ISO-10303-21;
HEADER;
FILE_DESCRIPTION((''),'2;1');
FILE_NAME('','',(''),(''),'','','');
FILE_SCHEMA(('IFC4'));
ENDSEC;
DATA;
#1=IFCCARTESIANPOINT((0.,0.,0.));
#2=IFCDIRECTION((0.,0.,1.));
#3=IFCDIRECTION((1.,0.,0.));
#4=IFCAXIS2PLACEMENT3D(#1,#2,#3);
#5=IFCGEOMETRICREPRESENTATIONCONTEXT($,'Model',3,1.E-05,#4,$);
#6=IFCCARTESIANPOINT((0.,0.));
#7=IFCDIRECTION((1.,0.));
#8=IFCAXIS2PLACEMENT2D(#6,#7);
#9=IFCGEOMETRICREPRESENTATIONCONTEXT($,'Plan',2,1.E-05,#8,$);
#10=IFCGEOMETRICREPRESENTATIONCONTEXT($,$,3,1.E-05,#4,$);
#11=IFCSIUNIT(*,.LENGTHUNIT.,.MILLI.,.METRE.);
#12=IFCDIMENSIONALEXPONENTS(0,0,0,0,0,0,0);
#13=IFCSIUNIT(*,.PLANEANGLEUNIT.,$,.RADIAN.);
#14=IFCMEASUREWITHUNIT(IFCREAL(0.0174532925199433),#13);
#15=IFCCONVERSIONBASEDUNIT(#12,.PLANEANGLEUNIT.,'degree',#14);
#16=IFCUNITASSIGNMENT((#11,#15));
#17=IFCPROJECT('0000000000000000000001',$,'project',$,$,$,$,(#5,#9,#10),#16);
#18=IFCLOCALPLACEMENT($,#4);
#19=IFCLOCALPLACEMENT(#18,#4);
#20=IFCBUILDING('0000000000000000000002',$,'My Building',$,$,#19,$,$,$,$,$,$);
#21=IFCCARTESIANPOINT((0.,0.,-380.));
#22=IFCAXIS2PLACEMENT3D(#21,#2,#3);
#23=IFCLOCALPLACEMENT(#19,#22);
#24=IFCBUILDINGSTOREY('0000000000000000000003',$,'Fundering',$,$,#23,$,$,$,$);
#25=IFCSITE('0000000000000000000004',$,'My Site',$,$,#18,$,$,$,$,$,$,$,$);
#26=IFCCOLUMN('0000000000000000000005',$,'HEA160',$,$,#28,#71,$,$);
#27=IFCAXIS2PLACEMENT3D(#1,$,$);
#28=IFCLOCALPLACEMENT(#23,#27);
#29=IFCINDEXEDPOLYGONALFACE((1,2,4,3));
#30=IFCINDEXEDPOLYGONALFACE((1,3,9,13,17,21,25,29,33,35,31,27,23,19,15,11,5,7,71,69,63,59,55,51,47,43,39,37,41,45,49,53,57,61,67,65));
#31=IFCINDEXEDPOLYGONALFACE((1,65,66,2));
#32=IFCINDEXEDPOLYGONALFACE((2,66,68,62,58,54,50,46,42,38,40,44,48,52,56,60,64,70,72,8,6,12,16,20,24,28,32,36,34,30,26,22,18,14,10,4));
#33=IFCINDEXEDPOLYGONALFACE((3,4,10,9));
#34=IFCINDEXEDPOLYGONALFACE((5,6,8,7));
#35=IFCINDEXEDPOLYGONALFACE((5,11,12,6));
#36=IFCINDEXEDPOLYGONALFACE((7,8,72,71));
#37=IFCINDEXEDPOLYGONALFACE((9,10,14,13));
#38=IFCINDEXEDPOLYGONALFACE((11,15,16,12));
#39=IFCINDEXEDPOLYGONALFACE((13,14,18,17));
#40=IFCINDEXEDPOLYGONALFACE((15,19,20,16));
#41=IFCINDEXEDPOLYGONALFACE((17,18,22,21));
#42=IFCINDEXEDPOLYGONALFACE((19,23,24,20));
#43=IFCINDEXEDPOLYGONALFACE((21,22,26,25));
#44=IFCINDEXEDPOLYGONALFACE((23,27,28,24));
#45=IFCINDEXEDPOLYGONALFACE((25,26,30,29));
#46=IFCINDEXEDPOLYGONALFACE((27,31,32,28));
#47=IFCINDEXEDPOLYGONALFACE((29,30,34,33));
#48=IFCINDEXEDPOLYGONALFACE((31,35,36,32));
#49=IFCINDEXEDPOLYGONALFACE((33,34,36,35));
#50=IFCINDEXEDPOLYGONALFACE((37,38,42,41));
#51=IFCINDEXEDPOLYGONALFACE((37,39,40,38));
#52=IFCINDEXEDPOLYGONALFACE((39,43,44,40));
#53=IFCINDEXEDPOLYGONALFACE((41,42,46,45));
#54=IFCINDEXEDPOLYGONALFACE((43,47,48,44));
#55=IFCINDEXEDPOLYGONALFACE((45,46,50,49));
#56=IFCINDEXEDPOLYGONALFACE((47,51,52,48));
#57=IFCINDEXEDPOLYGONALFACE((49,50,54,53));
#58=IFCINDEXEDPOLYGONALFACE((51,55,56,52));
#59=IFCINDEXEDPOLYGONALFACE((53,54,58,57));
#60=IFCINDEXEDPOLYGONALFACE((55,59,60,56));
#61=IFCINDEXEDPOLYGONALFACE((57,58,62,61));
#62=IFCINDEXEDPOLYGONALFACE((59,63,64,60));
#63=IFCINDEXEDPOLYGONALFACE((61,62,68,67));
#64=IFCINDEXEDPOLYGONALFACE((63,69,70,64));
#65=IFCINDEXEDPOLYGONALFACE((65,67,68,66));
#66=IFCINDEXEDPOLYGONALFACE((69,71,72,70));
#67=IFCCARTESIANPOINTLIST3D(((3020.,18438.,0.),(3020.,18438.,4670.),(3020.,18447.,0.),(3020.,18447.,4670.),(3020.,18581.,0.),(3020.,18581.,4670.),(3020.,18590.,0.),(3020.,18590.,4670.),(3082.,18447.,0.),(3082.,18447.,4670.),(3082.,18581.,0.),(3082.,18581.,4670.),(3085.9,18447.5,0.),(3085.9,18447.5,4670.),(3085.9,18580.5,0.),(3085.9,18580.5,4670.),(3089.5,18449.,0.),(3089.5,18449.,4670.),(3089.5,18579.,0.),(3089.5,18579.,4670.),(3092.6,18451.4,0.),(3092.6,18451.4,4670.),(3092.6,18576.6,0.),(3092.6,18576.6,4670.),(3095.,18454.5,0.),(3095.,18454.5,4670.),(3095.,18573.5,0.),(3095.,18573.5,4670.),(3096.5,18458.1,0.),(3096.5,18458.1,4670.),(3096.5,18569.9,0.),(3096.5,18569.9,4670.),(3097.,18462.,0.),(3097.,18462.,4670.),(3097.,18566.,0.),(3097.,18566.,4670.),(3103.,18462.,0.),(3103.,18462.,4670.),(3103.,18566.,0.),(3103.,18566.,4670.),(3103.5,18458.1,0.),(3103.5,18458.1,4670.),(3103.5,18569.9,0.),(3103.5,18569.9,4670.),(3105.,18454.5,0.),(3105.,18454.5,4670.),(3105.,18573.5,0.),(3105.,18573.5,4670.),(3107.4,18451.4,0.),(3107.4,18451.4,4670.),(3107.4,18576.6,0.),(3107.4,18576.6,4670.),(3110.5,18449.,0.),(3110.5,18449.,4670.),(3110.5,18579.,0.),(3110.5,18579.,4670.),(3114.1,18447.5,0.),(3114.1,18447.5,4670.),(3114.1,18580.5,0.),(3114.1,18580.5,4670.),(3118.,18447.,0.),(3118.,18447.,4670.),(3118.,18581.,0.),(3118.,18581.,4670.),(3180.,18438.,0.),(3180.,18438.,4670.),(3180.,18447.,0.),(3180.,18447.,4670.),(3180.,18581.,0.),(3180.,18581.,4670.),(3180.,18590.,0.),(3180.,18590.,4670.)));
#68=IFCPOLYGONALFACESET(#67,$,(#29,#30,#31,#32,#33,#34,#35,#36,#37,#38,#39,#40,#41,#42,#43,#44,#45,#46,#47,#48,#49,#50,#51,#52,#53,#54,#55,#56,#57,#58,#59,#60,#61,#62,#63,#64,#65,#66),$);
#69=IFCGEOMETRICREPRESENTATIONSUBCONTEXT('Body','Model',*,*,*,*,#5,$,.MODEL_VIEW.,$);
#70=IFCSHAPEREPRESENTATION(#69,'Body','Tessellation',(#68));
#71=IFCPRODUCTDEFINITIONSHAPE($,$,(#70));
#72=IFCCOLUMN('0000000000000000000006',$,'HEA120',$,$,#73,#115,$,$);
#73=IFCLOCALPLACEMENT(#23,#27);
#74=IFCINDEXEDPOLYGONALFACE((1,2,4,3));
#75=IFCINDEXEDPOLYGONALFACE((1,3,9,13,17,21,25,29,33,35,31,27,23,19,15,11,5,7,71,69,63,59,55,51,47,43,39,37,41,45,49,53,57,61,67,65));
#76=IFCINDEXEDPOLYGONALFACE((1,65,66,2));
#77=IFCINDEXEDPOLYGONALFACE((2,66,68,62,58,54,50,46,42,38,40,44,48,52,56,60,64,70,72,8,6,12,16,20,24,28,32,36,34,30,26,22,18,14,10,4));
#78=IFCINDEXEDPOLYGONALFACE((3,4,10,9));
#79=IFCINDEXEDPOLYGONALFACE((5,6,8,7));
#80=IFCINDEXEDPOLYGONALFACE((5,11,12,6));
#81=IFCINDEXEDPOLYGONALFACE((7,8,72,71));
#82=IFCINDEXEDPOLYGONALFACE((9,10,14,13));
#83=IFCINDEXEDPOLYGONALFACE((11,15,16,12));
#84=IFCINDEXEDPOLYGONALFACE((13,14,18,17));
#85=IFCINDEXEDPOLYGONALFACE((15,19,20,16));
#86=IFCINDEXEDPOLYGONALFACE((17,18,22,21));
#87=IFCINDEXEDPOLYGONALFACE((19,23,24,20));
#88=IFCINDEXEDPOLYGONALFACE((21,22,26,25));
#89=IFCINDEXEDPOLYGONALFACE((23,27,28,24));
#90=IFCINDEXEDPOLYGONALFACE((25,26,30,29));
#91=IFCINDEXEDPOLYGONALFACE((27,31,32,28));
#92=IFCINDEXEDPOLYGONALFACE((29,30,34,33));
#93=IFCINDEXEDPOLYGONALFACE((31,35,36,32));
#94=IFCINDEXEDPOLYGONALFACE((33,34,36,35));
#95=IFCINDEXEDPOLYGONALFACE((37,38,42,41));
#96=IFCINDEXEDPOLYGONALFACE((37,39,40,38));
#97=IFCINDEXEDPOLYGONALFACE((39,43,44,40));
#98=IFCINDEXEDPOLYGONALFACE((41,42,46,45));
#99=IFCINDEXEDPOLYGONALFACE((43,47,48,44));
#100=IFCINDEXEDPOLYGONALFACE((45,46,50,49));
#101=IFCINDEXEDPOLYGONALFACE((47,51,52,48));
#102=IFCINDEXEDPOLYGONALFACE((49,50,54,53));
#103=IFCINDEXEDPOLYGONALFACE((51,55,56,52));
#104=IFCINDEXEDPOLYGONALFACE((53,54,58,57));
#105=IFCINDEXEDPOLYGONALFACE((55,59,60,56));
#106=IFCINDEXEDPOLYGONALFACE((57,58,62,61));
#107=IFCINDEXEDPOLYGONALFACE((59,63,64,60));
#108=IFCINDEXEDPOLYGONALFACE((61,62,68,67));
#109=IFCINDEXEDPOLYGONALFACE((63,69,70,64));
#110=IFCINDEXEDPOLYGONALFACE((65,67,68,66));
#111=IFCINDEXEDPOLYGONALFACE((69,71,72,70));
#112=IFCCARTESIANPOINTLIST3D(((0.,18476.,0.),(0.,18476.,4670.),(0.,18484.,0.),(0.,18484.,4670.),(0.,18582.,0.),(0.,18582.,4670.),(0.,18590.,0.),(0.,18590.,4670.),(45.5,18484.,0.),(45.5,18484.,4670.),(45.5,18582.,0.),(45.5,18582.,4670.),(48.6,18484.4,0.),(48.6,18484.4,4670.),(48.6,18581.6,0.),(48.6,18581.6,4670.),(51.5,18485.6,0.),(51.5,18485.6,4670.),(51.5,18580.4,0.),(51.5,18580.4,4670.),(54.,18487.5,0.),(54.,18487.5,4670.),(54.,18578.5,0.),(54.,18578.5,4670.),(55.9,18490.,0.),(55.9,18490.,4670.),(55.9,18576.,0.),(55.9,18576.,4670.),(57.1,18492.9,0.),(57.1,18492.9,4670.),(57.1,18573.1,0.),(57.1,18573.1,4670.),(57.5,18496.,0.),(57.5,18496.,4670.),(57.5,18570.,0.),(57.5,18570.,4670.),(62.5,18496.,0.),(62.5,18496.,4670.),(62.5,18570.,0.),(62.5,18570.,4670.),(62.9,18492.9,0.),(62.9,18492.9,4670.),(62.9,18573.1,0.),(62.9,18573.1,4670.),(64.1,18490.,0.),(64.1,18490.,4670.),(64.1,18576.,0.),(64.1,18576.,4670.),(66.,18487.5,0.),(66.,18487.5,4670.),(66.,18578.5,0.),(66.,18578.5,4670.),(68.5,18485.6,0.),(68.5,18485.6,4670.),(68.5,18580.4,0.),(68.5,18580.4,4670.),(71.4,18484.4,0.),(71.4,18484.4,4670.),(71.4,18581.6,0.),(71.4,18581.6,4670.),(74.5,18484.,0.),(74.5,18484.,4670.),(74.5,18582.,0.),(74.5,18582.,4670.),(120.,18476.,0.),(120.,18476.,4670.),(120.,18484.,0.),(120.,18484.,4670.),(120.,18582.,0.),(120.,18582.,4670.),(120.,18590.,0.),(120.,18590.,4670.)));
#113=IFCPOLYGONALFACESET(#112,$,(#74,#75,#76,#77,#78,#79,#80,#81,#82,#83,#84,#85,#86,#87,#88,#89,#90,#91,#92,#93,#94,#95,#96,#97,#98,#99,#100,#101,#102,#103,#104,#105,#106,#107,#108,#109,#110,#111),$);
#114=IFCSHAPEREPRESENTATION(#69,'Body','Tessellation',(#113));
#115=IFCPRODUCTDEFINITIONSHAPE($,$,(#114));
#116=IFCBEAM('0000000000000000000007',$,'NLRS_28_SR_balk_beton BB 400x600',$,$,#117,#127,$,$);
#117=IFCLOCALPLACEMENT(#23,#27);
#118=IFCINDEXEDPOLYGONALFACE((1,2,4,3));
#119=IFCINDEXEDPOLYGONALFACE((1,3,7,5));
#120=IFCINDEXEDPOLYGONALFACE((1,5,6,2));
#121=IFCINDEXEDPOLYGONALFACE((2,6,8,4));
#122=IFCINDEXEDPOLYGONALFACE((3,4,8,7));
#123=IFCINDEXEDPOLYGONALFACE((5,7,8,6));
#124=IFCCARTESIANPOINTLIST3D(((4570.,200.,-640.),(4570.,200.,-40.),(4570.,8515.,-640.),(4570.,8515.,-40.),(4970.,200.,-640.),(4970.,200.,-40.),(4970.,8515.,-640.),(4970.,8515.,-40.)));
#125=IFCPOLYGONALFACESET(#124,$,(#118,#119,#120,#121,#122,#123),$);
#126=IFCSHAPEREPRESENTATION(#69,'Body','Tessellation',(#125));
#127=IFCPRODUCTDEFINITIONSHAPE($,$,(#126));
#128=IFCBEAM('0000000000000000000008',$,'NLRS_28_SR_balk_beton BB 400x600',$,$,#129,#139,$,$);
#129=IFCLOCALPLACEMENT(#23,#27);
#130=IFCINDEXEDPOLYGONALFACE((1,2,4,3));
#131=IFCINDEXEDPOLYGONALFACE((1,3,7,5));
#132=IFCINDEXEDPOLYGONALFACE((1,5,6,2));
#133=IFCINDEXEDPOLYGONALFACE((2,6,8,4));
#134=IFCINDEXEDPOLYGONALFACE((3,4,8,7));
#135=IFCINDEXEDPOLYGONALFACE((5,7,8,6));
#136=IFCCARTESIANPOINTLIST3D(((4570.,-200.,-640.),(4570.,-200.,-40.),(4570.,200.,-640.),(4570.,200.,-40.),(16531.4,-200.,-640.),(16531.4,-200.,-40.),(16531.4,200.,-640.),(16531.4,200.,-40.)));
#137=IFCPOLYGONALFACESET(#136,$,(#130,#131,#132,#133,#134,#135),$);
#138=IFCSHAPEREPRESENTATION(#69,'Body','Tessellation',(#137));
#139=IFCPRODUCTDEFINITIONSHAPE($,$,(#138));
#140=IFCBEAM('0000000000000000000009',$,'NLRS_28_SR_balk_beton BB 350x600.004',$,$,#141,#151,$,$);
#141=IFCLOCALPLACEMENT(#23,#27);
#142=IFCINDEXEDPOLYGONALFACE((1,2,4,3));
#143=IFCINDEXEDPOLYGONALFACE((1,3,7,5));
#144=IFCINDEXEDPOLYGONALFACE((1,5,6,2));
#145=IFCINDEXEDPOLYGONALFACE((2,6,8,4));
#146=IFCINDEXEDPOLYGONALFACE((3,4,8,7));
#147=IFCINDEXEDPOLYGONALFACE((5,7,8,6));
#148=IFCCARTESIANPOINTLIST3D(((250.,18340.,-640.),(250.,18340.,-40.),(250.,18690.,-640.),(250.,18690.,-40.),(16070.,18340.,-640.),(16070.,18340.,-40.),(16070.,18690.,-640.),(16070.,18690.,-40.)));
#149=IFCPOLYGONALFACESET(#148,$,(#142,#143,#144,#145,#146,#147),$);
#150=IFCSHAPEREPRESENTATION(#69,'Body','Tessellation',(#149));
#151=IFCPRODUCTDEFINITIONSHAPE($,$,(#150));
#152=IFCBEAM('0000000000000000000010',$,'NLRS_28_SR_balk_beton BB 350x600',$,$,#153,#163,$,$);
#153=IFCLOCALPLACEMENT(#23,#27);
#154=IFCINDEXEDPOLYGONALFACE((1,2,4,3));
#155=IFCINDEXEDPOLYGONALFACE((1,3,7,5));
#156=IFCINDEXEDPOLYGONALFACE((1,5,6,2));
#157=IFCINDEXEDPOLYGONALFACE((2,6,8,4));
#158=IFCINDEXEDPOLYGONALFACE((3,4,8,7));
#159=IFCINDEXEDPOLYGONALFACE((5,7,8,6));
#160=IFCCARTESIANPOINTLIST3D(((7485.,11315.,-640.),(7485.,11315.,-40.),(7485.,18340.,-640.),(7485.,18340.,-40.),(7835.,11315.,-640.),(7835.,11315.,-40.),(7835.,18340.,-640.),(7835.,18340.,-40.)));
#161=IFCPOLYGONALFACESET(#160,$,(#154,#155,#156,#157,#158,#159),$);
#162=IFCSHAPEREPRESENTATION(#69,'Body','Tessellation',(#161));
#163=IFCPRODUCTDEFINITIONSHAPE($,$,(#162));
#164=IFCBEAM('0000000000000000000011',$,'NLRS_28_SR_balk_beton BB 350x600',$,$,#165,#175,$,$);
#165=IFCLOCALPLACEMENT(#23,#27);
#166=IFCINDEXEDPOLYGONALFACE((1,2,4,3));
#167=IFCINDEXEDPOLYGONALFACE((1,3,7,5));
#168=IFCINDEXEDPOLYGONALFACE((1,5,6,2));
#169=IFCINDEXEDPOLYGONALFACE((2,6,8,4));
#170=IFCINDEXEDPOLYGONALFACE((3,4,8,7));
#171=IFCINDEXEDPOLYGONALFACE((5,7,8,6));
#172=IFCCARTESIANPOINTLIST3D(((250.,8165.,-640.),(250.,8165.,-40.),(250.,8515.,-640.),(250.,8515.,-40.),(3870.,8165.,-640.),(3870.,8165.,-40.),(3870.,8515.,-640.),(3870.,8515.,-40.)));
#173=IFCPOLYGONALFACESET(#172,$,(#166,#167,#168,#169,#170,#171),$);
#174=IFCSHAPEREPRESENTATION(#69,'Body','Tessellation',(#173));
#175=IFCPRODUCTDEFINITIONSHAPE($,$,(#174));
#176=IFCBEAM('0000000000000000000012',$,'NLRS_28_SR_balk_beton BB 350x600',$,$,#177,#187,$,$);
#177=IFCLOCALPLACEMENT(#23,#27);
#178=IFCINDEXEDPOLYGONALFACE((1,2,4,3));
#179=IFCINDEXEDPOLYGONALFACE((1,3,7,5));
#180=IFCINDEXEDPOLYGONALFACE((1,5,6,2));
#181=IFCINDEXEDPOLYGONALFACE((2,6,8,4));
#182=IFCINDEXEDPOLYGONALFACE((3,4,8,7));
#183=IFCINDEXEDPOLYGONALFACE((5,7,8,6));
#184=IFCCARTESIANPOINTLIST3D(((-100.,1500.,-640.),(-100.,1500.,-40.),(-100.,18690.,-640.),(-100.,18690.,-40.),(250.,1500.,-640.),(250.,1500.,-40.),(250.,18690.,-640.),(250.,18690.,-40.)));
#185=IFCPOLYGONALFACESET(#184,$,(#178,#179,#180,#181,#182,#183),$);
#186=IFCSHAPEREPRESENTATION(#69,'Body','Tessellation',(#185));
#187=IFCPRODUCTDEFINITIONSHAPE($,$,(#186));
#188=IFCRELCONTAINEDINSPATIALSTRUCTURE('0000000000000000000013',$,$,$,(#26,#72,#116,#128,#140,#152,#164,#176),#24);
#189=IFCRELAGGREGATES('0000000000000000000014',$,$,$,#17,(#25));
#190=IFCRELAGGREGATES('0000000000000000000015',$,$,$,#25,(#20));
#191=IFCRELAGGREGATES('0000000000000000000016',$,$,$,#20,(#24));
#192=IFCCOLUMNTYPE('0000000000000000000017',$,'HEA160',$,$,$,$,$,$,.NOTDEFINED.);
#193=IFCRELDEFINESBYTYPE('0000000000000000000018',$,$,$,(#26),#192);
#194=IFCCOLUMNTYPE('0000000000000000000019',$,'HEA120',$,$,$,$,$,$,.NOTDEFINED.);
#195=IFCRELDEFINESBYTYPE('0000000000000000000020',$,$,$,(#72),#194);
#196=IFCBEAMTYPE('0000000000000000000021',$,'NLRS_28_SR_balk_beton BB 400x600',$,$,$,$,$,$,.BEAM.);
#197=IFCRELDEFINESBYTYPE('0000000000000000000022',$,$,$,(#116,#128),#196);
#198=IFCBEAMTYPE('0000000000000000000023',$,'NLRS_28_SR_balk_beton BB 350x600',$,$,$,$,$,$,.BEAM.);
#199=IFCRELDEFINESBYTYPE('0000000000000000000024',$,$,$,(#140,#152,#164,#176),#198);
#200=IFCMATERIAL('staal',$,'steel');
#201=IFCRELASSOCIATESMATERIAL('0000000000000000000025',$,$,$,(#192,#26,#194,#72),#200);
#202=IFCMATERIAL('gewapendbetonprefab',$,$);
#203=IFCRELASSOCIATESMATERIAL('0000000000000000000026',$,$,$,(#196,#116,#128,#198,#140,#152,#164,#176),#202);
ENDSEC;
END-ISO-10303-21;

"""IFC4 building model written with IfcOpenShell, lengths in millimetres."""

from ifc_helpers import new_model, entity, si_unit, converted_unit, frame, origin_with_axes, origin_2d_with_axis, place, context, subcontext, project, spatial, rectangle, i_section, extrude, material, material_profile, profile_set, profile_usage, type_object, element, save


model = new_model("IFC4")

# Units and contexts
model_context = context("Model", 3, precision=1e-05, world=origin_with_axes())
plan_context = context("Plan", 2, precision=1e-05, world=origin_2d_with_axis())
context_of_model = context(None, 3, precision=1e-05, world=origin_with_axes())
body_context = subcontext(model_context, "Body", "Model", "MODEL_VIEW")
ifc_project = project(units=[si_unit("LENGTHUNIT", "METRE", prefix="MILLI"), converted_unit("PLANEANGLEUNIT", "degree", entity("IfcReal", 0.0174532925199433), si_unit("PLANEANGLEUNIT", "RADIAN"), dimensions=[0, 0, 0, 0, 0, 0, 0])], contexts=[model_context, plan_context, context_of_model])

# Site, building, storey
site_placement = place(None, origin_with_axes())
site = spatial("IfcSite", under=ifc_project, at=site_placement, Name="My Site")
building_placement = place(site_placement, origin_with_axes())
building = spatial("IfcBuilding", under=site, at=building_placement, Name="My Building")
storey_placement = place(building_placement, frame((0.0, 0.0, -380.0), z_axis=(0.0, 0.0, 1.0), x_axis=(1.0, 0.0, 0.0)))
storey = spatial("IfcBuildingStorey", under=building, at=storey_placement, Name="Fundering")

# Columns
ifc_material_1 = material(Name="staal", Category="steel")
ifc_material_profile_1 = material_profile(ifc_material_1, i_section(OverallWidth=160.0, OverallDepth=152.0, WebThickness=6.0, FlangeThickness=9.0, FilletRadius=15.0))
ifc_profile_set_1 = profile_set([ifc_material_profile_1], Name="HEA160")
ifc_profile_usage_1 = profile_usage(ifc_profile_set_1)
column_type_1 = type_object("IfcColumnType", Name="HEA160", PredefinedType="NOTDEFINED", material=ifc_profile_set_1)
column_1_placement = place(storey_placement, frame((3100.0, 18514.0, 0.0), z_axis=(0.0, 0.0, 1.0), x_axis=(1.0, 0.0, 0.0)))
element("IfcColumn", 1, at=column_1_placement, inside=storey, type_object=column_type_1, material=ifc_profile_usage_1, Name="HEA160", context=body_context, shape_type="SweptSolid", body=[
    extrude(i_section(OverallWidth=160.0, OverallDepth=152.0, WebThickness=6.0, FlangeThickness=9.0, FilletRadius=15.0), origin_with_axes(), (0.0, 0.0, 1.0), 4670.0),
])
ifc_material_profile_2 = material_profile(ifc_material_1, i_section(OverallWidth=120.0, OverallDepth=114.0, WebThickness=5.0, FlangeThickness=8.0, FilletRadius=12.0))
ifc_profile_set_2 = profile_set([ifc_material_profile_2], Name="HEA120")
ifc_profile_usage_2 = profile_usage(ifc_profile_set_2, cardinal=8)
column_type_2 = type_object("IfcColumnType", Name="HEA120", PredefinedType="NOTDEFINED", material=ifc_profile_set_2)
column_2_placement = place(storey_placement, frame((60.0, 18590.0, 0.0), z_axis=(0.0, 0.0, 1.0), x_axis=(1.0, 0.0, 0.0)))
element("IfcColumn", 2, at=column_2_placement, inside=storey, type_object=column_type_2, material=ifc_profile_usage_2, Name="HEA120", context=body_context, shape_type="SweptSolid", body=[
    extrude(i_section(OverallWidth=120.0, OverallDepth=114.0, WebThickness=5.0, FlangeThickness=8.0, FilletRadius=12.0), frame((0.0, -57.0, 0.0), z_axis=(0.0, 0.0, 1.0), x_axis=(1.0, 0.0, 0.0)), (0.0, 0.0, 1.0), 4670.0),
])

# Beams
ifc_material_2 = material(Name="gewapendbetonprefab")
ifc_material_profile_3 = material_profile(ifc_material_2, rectangle(XDim=400.0, YDim=600.0))
ifc_profile_set_3 = profile_set([ifc_material_profile_3], Name="NLRS_28_SR_balk_beton BB 400x600")
ifc_profile_usage_3 = profile_usage(ifc_profile_set_3, cardinal=8)
beam_type_1 = type_object("IfcBeamType", Name="NLRS_28_SR_balk_beton BB 400x600", PredefinedType="BEAM", material=ifc_profile_set_3)
beam_1_placement = place(storey_placement, frame((4770.0, 200.0, -40.0), z_axis=(0.0, 1.0, 0.0), x_axis=(-1.0, 0.0, 0.0)))
element("IfcBeam", 3, at=beam_1_placement, inside=storey, type_object=beam_type_1, material=ifc_profile_usage_3, Name="NLRS_28_SR_balk_beton BB 400x600", context=body_context, shape_type="SweptSolid", body=[
    extrude(rectangle(XDim=400.0, YDim=600.0), frame((0.0, -300.0, 0.0), z_axis=(0.0, 0.0, 1.0), x_axis=(1.0, 0.0, 0.0)), (0.0, 0.0, 1.0), 8315.0),
])
ifc_profile_usage_4 = profile_usage(ifc_profile_set_3, cardinal=8)
beam_2_placement = place(storey_placement, frame((4570.0, 0.0, -40.0), z_axis=(1.0, 0.0, 0.0), x_axis=(0.0, 1.0, 0.0)))
element("IfcBeam", 4, at=beam_2_placement, inside=storey, type_object=beam_type_1, material=ifc_profile_usage_4, Name="NLRS_28_SR_balk_beton BB 400x600", context=body_context, shape_type="SweptSolid", body=[
    extrude(rectangle(XDim=400.0, YDim=600.0), frame((0.0, -300.0, 0.0), z_axis=(0.0, 0.0, 1.0), x_axis=(1.0, 0.0, 0.0)), (0.0, 0.0, 1.0), 11961.4),
])
ifc_material_profile_4 = material_profile(ifc_material_2, rectangle(XDim=350.0, YDim=600.0))
ifc_profile_set_4 = profile_set([ifc_material_profile_4], Name="NLRS_28_SR_balk_beton BB 350x600")
ifc_profile_usage_5 = profile_usage(ifc_profile_set_4, cardinal=8)
beam_type_2 = type_object("IfcBeamType", Name="NLRS_28_SR_balk_beton BB 350x600", PredefinedType="BEAM", material=ifc_profile_set_4)
beam_3_placement = place(storey_placement, frame((250.0, 18515.0, -40.0), z_axis=(1.0, 0.0, 0.0), x_axis=(0.0, 1.0, 0.0)))
element("IfcBeam", 5, at=beam_3_placement, inside=storey, type_object=beam_type_2, material=ifc_profile_usage_5, Name="NLRS_28_SR_balk_beton BB 350x600.004", context=body_context, shape_type="SweptSolid", body=[
    extrude(rectangle(XDim=350.0, YDim=600.0), frame((0.0, -300.0, 0.0), z_axis=(0.0, 0.0, 1.0), x_axis=(1.0, 0.0, 0.0)), (0.0, 0.0, 1.0), 15820.0),
])
ifc_profile_usage_6 = profile_usage(ifc_profile_set_4, cardinal=8)
beam_4_placement = place(storey_placement, frame((7660.0, 11315.0, -40.0), z_axis=(0.0, 1.0, 0.0), x_axis=(-1.0, 0.0, 0.0)))
element("IfcBeam", 6, at=beam_4_placement, inside=storey, type_object=beam_type_2, material=ifc_profile_usage_6, Name="NLRS_28_SR_balk_beton BB 350x600", context=body_context, shape_type="SweptSolid", body=[
    extrude(rectangle(XDim=350.0, YDim=600.0), frame((0.0, -300.0, 0.0), z_axis=(0.0, 0.0, 1.0), x_axis=(1.0, 0.0, 0.0)), (0.0, 0.0, 1.0), 7025.0),
])
ifc_profile_usage_7 = profile_usage(ifc_profile_set_4, cardinal=8)
beam_5_placement = place(storey_placement, frame((3870.0, 8340.0, -40.0), z_axis=(-1.0, 0.0, 0.0), x_axis=(0.0, -1.0, 0.0)))
element("IfcBeam", 7, at=beam_5_placement, inside=storey, type_object=beam_type_2, material=ifc_profile_usage_7, Name="NLRS_28_SR_balk_beton BB 350x600", context=body_context, shape_type="SweptSolid", body=[
    extrude(rectangle(XDim=350.0, YDim=600.0), frame((0.0, -300.0, 0.0), z_axis=(0.0, 0.0, 1.0), x_axis=(1.0, 0.0, 0.0)), (0.0, 0.0, 1.0), 3620.0),
])
ifc_profile_usage_8 = profile_usage(ifc_profile_set_4, cardinal=8)
beam_6_placement = place(storey_placement, frame((75.0, 1500.0, -40.0), z_axis=(0.0, 1.0, 0.0), x_axis=(-1.0, 0.0, 0.0)))
element("IfcBeam", 8, at=beam_6_placement, inside=storey, type_object=beam_type_2, material=ifc_profile_usage_8, Name="NLRS_28_SR_balk_beton BB 350x600", context=body_context, shape_type="SweptSolid", body=[
    extrude(rectangle(XDim=350.0, YDim=600.0), frame((0.0, -300.0, 0.0), z_axis=(0.0, 0.0, 1.0), x_axis=(1.0, 0.0, 0.0)), (0.0, 0.0, 1.0), 17190.0),
])

save(model, "model.ifc")
